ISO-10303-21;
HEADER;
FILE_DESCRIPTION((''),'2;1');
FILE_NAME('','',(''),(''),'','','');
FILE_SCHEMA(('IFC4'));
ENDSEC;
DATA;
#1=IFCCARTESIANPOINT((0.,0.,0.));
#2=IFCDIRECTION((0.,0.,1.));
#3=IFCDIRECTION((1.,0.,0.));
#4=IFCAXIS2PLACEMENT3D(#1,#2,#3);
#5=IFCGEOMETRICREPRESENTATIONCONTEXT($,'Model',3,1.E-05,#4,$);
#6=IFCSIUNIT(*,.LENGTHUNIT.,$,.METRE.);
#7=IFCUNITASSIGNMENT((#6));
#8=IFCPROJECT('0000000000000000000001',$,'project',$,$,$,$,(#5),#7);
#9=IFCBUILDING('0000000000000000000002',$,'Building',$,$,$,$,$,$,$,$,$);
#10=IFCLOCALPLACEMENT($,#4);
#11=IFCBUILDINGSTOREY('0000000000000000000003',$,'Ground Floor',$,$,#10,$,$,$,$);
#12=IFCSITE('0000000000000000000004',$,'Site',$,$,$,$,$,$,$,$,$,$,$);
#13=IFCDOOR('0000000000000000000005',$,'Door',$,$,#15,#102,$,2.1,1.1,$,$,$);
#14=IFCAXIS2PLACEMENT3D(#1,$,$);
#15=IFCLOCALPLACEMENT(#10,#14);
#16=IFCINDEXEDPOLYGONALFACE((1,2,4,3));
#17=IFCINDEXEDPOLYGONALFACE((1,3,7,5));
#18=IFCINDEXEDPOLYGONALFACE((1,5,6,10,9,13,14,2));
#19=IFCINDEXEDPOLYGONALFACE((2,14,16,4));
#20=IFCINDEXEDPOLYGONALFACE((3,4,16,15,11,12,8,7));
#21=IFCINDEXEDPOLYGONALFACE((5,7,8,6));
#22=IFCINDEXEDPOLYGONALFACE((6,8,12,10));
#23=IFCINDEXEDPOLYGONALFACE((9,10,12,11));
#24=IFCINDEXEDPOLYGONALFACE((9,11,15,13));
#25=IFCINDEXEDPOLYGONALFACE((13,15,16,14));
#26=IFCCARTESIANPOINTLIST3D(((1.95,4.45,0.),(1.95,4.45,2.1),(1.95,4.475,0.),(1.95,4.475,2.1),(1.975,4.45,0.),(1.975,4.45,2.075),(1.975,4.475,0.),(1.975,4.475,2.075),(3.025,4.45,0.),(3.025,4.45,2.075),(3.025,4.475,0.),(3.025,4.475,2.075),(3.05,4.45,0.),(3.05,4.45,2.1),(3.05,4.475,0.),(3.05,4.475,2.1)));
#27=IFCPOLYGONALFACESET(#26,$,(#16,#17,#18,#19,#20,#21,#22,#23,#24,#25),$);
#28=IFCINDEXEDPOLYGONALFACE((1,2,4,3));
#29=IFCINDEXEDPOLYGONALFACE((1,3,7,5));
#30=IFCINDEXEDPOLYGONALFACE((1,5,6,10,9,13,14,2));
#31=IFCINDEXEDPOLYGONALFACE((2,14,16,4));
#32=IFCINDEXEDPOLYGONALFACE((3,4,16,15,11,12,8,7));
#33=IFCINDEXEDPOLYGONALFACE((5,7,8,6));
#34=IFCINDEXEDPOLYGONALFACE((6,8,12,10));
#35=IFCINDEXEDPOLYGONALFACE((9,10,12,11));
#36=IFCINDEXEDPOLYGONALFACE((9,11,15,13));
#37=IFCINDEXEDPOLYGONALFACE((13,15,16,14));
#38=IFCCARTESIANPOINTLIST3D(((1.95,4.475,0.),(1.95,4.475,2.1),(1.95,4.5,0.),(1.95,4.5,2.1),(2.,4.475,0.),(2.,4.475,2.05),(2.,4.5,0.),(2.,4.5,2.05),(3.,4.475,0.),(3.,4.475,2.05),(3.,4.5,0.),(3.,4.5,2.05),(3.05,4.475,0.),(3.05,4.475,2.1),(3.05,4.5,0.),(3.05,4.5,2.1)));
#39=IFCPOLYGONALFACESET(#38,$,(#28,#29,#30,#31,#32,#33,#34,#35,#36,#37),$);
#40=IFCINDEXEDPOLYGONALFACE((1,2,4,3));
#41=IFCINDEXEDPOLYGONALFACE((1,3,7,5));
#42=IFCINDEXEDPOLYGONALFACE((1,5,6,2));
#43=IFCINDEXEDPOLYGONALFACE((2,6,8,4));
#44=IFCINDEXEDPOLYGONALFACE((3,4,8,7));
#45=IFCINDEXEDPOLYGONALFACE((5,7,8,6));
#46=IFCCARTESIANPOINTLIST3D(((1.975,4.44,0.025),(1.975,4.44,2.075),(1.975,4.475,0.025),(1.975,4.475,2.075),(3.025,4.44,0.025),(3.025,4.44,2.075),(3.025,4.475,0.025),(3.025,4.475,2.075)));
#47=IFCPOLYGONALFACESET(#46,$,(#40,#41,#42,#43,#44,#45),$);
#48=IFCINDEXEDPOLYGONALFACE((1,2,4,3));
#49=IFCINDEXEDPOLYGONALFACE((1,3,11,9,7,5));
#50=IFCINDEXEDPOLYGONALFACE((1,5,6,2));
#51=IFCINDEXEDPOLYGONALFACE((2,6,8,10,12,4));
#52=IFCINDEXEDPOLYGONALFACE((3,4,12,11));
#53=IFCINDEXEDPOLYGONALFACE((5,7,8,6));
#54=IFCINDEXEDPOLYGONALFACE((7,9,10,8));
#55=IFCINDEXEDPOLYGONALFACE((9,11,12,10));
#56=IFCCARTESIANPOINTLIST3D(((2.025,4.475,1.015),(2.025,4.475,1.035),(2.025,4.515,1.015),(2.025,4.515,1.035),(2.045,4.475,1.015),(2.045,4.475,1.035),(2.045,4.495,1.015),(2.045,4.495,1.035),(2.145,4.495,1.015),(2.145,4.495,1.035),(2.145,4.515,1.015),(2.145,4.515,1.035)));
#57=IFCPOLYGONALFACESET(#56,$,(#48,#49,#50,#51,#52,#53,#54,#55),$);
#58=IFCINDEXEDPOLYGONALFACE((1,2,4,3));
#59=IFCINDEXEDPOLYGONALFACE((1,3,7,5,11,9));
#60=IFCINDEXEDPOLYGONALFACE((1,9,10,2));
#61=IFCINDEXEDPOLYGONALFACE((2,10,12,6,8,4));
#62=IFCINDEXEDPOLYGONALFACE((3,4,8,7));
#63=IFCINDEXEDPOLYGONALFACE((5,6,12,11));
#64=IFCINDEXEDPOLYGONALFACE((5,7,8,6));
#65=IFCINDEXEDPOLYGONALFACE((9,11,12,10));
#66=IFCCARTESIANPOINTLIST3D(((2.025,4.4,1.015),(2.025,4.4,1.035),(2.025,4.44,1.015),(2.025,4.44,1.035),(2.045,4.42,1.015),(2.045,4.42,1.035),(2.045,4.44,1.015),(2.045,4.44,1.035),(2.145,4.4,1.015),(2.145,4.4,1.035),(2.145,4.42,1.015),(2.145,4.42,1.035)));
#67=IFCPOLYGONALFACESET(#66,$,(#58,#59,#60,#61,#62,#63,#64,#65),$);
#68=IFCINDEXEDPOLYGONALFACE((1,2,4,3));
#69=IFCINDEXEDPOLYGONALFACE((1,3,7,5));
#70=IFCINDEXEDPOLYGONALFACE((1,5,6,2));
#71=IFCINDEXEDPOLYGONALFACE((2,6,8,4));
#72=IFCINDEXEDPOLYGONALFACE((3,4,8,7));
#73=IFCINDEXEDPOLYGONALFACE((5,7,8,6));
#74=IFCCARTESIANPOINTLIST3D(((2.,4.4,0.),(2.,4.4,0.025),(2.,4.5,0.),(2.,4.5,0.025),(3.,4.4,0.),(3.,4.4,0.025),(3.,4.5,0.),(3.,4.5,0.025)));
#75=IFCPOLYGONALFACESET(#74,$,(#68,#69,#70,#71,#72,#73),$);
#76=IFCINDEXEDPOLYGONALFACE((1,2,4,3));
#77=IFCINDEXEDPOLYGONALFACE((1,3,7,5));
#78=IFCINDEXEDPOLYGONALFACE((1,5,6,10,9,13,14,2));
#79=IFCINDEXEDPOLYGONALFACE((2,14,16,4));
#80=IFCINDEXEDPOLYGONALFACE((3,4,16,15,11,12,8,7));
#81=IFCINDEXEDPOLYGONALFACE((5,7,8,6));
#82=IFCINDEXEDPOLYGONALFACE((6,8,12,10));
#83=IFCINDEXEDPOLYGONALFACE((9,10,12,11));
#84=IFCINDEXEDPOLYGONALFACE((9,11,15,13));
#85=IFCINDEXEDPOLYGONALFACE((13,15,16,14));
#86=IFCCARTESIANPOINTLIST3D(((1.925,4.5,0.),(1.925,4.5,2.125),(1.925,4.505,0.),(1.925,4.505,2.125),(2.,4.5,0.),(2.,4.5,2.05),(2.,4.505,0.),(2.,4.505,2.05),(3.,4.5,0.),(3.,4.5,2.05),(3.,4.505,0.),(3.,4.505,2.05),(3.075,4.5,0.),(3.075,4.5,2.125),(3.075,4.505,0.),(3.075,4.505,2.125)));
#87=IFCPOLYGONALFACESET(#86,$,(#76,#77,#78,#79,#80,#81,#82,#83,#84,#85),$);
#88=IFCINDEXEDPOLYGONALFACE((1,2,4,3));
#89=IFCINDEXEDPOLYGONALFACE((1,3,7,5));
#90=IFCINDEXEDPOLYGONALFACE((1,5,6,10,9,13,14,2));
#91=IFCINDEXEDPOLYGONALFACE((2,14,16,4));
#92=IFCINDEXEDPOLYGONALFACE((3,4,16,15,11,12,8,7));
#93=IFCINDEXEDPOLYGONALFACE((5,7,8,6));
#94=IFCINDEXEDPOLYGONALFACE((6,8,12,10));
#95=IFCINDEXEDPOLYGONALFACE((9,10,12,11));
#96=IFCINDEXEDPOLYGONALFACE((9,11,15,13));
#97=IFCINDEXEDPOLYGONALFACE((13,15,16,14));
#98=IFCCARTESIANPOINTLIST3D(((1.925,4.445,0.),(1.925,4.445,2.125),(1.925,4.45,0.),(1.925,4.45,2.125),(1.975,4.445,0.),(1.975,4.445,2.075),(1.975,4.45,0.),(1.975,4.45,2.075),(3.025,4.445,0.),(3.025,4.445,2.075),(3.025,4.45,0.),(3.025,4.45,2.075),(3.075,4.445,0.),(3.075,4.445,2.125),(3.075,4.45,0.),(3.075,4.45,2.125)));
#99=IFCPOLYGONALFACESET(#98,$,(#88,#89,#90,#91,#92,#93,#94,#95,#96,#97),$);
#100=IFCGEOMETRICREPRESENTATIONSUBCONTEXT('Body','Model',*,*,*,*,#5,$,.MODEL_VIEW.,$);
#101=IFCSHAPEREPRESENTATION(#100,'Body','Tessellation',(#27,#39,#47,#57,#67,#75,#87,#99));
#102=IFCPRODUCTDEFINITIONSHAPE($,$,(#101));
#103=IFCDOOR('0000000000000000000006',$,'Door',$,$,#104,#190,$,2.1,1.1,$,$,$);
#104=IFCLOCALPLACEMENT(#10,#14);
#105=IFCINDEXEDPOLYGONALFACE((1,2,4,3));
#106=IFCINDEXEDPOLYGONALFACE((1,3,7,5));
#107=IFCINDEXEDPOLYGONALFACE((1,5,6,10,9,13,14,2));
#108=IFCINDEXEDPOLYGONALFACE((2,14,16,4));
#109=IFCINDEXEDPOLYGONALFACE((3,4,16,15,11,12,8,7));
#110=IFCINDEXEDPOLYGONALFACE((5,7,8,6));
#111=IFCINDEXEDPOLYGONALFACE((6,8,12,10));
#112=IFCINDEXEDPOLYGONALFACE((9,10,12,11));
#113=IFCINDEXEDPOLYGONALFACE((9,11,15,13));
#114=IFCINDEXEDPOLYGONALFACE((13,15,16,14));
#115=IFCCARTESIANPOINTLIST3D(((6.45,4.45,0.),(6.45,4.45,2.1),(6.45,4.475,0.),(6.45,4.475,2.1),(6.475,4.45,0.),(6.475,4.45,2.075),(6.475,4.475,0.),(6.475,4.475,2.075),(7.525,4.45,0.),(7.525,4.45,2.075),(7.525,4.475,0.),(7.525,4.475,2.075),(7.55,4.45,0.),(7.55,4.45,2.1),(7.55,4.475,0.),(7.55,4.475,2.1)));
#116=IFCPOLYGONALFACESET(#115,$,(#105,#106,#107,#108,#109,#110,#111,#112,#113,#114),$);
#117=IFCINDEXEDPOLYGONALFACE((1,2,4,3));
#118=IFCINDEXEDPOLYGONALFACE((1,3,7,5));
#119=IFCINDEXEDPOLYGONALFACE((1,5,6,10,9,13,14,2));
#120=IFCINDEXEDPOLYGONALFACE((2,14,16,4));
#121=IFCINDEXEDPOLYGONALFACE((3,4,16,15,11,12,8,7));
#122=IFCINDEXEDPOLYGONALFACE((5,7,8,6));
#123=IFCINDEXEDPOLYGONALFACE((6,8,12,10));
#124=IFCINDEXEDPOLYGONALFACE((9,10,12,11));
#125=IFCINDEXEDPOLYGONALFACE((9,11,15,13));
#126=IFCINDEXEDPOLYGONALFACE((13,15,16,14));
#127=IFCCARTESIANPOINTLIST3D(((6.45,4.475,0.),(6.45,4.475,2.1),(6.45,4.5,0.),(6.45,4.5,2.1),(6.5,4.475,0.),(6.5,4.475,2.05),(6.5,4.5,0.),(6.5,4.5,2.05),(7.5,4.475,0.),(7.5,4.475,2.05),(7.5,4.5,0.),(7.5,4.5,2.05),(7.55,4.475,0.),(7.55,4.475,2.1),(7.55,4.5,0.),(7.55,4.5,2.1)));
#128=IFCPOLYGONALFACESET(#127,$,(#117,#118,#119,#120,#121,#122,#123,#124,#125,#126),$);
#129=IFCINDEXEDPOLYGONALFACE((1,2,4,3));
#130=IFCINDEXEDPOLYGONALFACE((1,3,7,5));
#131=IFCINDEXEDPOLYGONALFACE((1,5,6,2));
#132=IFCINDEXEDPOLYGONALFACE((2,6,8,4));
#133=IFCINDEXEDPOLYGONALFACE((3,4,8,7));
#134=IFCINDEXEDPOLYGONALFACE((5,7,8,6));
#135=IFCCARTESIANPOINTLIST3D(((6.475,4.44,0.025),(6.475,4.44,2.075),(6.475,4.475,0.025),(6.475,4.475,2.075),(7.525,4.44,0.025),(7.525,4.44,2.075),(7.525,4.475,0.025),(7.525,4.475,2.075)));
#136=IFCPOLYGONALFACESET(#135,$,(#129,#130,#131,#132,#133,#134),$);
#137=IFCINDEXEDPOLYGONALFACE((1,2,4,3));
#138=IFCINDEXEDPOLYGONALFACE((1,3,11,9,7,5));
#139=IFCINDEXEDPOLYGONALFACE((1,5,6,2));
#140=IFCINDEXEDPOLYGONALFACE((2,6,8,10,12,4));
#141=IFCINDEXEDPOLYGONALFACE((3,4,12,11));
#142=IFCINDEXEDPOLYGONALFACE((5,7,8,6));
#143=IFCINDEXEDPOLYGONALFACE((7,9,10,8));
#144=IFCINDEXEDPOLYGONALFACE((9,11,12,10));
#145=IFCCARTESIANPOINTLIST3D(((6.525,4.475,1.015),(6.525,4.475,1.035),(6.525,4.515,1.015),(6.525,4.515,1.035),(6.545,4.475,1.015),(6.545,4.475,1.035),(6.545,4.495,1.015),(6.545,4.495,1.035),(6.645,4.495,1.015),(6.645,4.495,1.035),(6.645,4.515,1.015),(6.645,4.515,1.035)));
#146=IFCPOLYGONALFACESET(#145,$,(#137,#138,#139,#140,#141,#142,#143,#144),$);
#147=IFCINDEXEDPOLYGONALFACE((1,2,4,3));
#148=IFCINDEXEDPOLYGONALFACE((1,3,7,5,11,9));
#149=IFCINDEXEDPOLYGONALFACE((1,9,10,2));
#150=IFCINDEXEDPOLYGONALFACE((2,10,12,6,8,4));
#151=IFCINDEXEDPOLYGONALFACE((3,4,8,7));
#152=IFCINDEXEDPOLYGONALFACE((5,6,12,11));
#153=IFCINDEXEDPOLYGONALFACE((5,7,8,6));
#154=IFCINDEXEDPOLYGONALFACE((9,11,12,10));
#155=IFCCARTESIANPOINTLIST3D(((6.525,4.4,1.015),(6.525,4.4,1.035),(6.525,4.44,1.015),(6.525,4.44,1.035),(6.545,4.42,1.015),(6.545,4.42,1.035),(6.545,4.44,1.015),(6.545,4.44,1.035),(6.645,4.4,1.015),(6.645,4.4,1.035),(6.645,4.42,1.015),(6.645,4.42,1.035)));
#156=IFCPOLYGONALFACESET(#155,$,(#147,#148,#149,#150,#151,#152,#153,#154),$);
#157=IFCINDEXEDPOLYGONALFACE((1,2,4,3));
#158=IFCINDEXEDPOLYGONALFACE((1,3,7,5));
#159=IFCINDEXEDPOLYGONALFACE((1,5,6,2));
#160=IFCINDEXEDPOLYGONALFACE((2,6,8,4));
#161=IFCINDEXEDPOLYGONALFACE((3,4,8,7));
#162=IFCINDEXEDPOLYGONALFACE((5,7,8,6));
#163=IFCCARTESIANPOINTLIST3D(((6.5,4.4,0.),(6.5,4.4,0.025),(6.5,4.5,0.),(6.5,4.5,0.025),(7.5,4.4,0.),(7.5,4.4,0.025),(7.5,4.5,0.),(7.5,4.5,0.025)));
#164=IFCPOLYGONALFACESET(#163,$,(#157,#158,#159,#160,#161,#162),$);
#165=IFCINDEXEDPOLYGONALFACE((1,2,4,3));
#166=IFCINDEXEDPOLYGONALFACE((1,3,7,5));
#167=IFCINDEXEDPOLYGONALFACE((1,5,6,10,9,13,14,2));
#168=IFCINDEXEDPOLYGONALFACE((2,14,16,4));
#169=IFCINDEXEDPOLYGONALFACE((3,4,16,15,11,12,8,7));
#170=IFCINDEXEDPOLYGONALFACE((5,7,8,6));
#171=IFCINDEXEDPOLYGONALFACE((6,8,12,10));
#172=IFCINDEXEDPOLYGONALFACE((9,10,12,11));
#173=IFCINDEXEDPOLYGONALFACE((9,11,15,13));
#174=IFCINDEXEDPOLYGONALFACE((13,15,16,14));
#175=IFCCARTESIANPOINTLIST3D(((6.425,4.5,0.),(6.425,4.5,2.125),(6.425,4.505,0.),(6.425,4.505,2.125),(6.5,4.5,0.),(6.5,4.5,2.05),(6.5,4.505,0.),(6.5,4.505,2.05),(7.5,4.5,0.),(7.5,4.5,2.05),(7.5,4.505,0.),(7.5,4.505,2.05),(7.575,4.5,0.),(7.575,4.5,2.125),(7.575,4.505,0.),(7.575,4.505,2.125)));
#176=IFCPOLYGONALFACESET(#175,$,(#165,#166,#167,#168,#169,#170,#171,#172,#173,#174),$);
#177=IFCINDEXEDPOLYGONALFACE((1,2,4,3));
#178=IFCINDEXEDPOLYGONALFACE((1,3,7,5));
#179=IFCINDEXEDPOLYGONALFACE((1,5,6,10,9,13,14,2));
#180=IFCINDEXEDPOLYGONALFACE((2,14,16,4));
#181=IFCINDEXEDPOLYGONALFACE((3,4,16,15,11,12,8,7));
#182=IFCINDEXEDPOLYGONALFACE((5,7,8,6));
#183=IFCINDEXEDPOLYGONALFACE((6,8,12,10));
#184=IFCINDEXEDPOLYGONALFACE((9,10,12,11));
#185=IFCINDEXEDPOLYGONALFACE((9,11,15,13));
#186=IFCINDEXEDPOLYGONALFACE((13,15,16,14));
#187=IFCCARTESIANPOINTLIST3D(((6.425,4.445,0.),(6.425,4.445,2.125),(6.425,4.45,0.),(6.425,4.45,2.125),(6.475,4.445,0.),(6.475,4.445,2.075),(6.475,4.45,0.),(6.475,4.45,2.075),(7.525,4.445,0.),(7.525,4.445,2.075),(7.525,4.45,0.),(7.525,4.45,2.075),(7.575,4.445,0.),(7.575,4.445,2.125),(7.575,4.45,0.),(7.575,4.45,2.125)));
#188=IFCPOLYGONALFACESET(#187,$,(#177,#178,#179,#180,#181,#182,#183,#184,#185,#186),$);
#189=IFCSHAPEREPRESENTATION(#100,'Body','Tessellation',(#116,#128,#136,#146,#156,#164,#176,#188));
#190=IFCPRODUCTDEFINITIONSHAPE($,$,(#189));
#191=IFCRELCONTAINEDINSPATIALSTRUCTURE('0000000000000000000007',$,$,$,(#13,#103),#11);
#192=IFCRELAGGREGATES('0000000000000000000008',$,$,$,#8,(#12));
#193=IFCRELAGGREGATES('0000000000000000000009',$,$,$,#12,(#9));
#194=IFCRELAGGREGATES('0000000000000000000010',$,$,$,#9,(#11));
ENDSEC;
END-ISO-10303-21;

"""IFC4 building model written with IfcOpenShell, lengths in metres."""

from ifc_helpers import new_model, si_unit, frame, origin_with_axes, place, context, subcontext, project, spatial, line, indexed_curve, outline, extrude, element, save


model = new_model("IFC4")

# Units and contexts
model_context = context("Model", 3, precision=1e-05, world=origin_with_axes())
body_context = subcontext(model_context, "Body", "Model", "MODEL_VIEW")
ifc_project = project(units=[si_unit("LENGTHUNIT", "METRE")], contexts=[model_context])

# Site, building, storey
site = spatial("IfcSite", under=ifc_project, Name="Site")
building = spatial("IfcBuilding", under=site, Name="Building")
storey_placement = place(None, origin_with_axes())
storey = spatial("IfcBuildingStorey", under=building, at=storey_placement, Name="Ground Floor")

# Doors
door_1_placement = place(storey_placement, frame((3.05, 4.5, 0.0), z_axis=(0.0, 0.0, 1.0), x_axis=(-1.0, 0.0, 0.0)))
element("IfcDoor", 1, at=door_1_placement, inside=storey, Name="Door", OverallHeight=2.1, OverallWidth=1.1, context=body_context, shape_type="SweptSolid", body=[
    extrude(outline(indexed_curve([(0.0, 0.0), (0.0, 2.1), (1.1, 2.1), (1.1, 0.0), (1.075, 0.0), (1.075, 2.075), (0.025, 2.075), (0.025, 0.0)], segments=[line(1, 2, 3, 4, 5, 6, 7, 8, 1)])), frame((0.0, 0.025, 0.0), z_axis=(0.0, -1.0, 0.0), x_axis=(1.0, 0.0, 0.0)), (0.0, 0.0, -1.0), 0.025),
    extrude(outline(indexed_curve([(0.0, 0.0), (0.0, 2.1), (1.1, 2.1), (1.1, 0.0), (1.05, 0.0), (1.05, 2.05), (0.05, 2.05), (0.05, 0.0)], segments=[line(1, 2, 3, 4, 5, 6, 7, 8, 1)])), frame((0.0, 0.0, 0.0), z_axis=(0.0, -1.0, 0.0), x_axis=(1.0, 0.0, 0.0)), (0.0, 0.0, -1.0), 0.025),
    extrude(outline(indexed_curve([(0.0, 0.0), (1.05, 0.0), (1.05, 0.035), (0.0, 0.035)], segments=[line(1, 2, 3, 4, 1)])), frame((0.025, 0.025, 0.025), z_axis=(0.0, 0.0, 1.0), x_axis=(1.0, 0.0, 0.0)), (0.0, 0.0, 1.0), 2.05),
    extrude(outline(indexed_curve([(0.0, 0.0), (0.0, -0.04), (-0.12, -0.04), (-0.12, -0.02), (-0.02, -0.02), (-0.02, 0.0)], segments=[line(1, 2, 3, 4, 5, 6, 1)])), frame((1.025, 0.025, 1.015), z_axis=(0.0, 0.0, 1.0), x_axis=(1.0, 0.0, 0.0)), (0.0, 0.0, 1.0), 0.02),
    extrude(outline(indexed_curve([(0.0, 0.0), (0.0, 0.04), (-0.12, 0.04), (-0.12, 0.02), (-0.02, 0.02), (-0.02, 0.0)], segments=[line(1, 2, 3, 4, 5, 6, 1)])), frame((1.025, 0.06, 1.015), z_axis=(0.0, 0.0, 1.0), x_axis=(1.0, 0.0, 0.0)), (0.0, 0.0, 1.0), 0.02),
    extrude(outline(indexed_curve([(0.0, 0.0), (1.0, 0.0), (1.0, 0.1), (0.0, 0.1)], segments=[line(1, 2, 3, 4, 1)])), frame((0.05, 0.0, 0.0), z_axis=(0.0, 0.0, 1.0), x_axis=(1.0, 0.0, 0.0)), (0.0, 0.0, 1.0), 0.025),
    extrude(outline(indexed_curve([(0.0, 0.0), (0.0, 2.125), (1.15, 2.125), (1.15, 0.0), (1.075, 0.0), (1.075, 2.05), (0.075, 2.05), (0.075, 0.0)], segments=[line(1, 2, 3, 4, 5, 6, 7, 8, 1)])), frame((-0.025, -0.005, 0.0), z_axis=(0.0, -1.0, 0.0), x_axis=(1.0, 0.0, 0.0)), (0.0, 0.0, -1.0), 0.005),
    extrude(outline(indexed_curve([(0.0, 0.0), (0.0, 2.125), (1.15, 2.125), (1.15, 0.0), (1.1, 0.0), (1.1, 2.075), (0.05, 2.075), (0.05, 0.0)], segments=[line(1, 2, 3, 4, 5, 6, 7, 8, 1)])), frame((-0.025, 0.05, 0.0), z_axis=(0.0, -1.0, 0.0), x_axis=(1.0, 0.0, 0.0)), (0.0, 0.0, -1.0), 0.005),
])
door_2_placement = place(storey_placement, frame((7.55, 4.5, 0.0), z_axis=(0.0, 0.0, 1.0), x_axis=(-1.0, 0.0, 0.0)))
element("IfcDoor", 2, at=door_2_placement, inside=storey, Name="Door", OverallHeight=2.1, OverallWidth=1.1, context=body_context, shape_type="SweptSolid", body=[
    extrude(outline(indexed_curve([(0.0, 0.0), (0.0, 2.1), (1.1, 2.1), (1.1, 0.0), (1.075, 0.0), (1.075, 2.075), (0.025, 2.075), (0.025, 0.0)], segments=[line(1, 2, 3, 4, 5, 6, 7, 8, 1)])), frame((0.0, 0.025, 0.0), z_axis=(0.0, -1.0, 0.0), x_axis=(1.0, 0.0, 0.0)), (0.0, 0.0, -1.0), 0.025),
    extrude(outline(indexed_curve([(0.0, 0.0), (0.0, 2.1), (1.1, 2.1), (1.1, 0.0), (1.05, 0.0), (1.05, 2.05), (0.05, 2.05), (0.05, 0.0)], segments=[line(1, 2, 3, 4, 5, 6, 7, 8, 1)])), frame((0.0, 0.0, 0.0), z_axis=(0.0, -1.0, 0.0), x_axis=(1.0, 0.0, 0.0)), (0.0, 0.0, -1.0), 0.025),
    extrude(outline(indexed_curve([(0.0, 0.0), (1.05, 0.0), (1.05, 0.035), (0.0, 0.035)], segments=[line(1, 2, 3, 4, 1)])), frame((0.025, 0.025, 0.025), z_axis=(0.0, 0.0, 1.0), x_axis=(1.0, 0.0, 0.0)), (0.0, 0.0, 1.0), 2.05),
    extrude(outline(indexed_curve([(0.0, 0.0), (0.0, -0.04), (-0.12, -0.04), (-0.12, -0.02), (-0.02, -0.02), (-0.02, 0.0)], segments=[line(1, 2, 3, 4, 5, 6, 1)])), frame((1.025, 0.025, 1.015), z_axis=(0.0, 0.0, 1.0), x_axis=(1.0, 0.0, 0.0)), (0.0, 0.0, 1.0), 0.02),
    extrude(outline(indexed_curve([(0.0, 0.0), (0.0, 0.04), (-0.12, 0.04), (-0.12, 0.02), (-0.02, 0.02), (-0.02, 0.0)], segments=[line(1, 2, 3, 4, 5, 6, 1)])), frame((1.025, 0.06, 1.015), z_axis=(0.0, 0.0, 1.0), x_axis=(1.0, 0.0, 0.0)), (0.0, 0.0, 1.0), 0.02),
    extrude(outline(indexed_curve([(0.0, 0.0), (1.0, 0.0), (1.0, 0.1), (0.0, 0.1)], segments=[line(1, 2, 3, 4, 1)])), frame((0.05, 0.0, 0.0), z_axis=(0.0, 0.0, 1.0), x_axis=(1.0, 0.0, 0.0)), (0.0, 0.0, 1.0), 0.025),
    extrude(outline(indexed_curve([(0.0, 0.0), (0.0, 2.125), (1.15, 2.125), (1.15, 0.0), (1.075, 0.0), (1.075, 2.05), (0.075, 2.05), (0.075, 0.0)], segments=[line(1, 2, 3, 4, 5, 6, 7, 8, 1)])), frame((-0.025, -0.005, 0.0), z_axis=(0.0, -1.0, 0.0), x_axis=(1.0, 0.0, 0.0)), (0.0, 0.0, -1.0), 0.005),
    extrude(outline(indexed_curve([(0.0, 0.0), (0.0, 2.125), (1.15, 2.125), (1.15, 0.0), (1.1, 0.0), (1.1, 2.075), (0.05, 2.075), (0.05, 0.0)], segments=[line(1, 2, 3, 4, 5, 6, 7, 8, 1)])), frame((-0.025, 0.05, 0.0), z_axis=(0.0, -1.0, 0.0), x_axis=(1.0, 0.0, 0.0)), (0.0, 0.0, -1.0), 0.005),
])

save(model, "model.ifc")
